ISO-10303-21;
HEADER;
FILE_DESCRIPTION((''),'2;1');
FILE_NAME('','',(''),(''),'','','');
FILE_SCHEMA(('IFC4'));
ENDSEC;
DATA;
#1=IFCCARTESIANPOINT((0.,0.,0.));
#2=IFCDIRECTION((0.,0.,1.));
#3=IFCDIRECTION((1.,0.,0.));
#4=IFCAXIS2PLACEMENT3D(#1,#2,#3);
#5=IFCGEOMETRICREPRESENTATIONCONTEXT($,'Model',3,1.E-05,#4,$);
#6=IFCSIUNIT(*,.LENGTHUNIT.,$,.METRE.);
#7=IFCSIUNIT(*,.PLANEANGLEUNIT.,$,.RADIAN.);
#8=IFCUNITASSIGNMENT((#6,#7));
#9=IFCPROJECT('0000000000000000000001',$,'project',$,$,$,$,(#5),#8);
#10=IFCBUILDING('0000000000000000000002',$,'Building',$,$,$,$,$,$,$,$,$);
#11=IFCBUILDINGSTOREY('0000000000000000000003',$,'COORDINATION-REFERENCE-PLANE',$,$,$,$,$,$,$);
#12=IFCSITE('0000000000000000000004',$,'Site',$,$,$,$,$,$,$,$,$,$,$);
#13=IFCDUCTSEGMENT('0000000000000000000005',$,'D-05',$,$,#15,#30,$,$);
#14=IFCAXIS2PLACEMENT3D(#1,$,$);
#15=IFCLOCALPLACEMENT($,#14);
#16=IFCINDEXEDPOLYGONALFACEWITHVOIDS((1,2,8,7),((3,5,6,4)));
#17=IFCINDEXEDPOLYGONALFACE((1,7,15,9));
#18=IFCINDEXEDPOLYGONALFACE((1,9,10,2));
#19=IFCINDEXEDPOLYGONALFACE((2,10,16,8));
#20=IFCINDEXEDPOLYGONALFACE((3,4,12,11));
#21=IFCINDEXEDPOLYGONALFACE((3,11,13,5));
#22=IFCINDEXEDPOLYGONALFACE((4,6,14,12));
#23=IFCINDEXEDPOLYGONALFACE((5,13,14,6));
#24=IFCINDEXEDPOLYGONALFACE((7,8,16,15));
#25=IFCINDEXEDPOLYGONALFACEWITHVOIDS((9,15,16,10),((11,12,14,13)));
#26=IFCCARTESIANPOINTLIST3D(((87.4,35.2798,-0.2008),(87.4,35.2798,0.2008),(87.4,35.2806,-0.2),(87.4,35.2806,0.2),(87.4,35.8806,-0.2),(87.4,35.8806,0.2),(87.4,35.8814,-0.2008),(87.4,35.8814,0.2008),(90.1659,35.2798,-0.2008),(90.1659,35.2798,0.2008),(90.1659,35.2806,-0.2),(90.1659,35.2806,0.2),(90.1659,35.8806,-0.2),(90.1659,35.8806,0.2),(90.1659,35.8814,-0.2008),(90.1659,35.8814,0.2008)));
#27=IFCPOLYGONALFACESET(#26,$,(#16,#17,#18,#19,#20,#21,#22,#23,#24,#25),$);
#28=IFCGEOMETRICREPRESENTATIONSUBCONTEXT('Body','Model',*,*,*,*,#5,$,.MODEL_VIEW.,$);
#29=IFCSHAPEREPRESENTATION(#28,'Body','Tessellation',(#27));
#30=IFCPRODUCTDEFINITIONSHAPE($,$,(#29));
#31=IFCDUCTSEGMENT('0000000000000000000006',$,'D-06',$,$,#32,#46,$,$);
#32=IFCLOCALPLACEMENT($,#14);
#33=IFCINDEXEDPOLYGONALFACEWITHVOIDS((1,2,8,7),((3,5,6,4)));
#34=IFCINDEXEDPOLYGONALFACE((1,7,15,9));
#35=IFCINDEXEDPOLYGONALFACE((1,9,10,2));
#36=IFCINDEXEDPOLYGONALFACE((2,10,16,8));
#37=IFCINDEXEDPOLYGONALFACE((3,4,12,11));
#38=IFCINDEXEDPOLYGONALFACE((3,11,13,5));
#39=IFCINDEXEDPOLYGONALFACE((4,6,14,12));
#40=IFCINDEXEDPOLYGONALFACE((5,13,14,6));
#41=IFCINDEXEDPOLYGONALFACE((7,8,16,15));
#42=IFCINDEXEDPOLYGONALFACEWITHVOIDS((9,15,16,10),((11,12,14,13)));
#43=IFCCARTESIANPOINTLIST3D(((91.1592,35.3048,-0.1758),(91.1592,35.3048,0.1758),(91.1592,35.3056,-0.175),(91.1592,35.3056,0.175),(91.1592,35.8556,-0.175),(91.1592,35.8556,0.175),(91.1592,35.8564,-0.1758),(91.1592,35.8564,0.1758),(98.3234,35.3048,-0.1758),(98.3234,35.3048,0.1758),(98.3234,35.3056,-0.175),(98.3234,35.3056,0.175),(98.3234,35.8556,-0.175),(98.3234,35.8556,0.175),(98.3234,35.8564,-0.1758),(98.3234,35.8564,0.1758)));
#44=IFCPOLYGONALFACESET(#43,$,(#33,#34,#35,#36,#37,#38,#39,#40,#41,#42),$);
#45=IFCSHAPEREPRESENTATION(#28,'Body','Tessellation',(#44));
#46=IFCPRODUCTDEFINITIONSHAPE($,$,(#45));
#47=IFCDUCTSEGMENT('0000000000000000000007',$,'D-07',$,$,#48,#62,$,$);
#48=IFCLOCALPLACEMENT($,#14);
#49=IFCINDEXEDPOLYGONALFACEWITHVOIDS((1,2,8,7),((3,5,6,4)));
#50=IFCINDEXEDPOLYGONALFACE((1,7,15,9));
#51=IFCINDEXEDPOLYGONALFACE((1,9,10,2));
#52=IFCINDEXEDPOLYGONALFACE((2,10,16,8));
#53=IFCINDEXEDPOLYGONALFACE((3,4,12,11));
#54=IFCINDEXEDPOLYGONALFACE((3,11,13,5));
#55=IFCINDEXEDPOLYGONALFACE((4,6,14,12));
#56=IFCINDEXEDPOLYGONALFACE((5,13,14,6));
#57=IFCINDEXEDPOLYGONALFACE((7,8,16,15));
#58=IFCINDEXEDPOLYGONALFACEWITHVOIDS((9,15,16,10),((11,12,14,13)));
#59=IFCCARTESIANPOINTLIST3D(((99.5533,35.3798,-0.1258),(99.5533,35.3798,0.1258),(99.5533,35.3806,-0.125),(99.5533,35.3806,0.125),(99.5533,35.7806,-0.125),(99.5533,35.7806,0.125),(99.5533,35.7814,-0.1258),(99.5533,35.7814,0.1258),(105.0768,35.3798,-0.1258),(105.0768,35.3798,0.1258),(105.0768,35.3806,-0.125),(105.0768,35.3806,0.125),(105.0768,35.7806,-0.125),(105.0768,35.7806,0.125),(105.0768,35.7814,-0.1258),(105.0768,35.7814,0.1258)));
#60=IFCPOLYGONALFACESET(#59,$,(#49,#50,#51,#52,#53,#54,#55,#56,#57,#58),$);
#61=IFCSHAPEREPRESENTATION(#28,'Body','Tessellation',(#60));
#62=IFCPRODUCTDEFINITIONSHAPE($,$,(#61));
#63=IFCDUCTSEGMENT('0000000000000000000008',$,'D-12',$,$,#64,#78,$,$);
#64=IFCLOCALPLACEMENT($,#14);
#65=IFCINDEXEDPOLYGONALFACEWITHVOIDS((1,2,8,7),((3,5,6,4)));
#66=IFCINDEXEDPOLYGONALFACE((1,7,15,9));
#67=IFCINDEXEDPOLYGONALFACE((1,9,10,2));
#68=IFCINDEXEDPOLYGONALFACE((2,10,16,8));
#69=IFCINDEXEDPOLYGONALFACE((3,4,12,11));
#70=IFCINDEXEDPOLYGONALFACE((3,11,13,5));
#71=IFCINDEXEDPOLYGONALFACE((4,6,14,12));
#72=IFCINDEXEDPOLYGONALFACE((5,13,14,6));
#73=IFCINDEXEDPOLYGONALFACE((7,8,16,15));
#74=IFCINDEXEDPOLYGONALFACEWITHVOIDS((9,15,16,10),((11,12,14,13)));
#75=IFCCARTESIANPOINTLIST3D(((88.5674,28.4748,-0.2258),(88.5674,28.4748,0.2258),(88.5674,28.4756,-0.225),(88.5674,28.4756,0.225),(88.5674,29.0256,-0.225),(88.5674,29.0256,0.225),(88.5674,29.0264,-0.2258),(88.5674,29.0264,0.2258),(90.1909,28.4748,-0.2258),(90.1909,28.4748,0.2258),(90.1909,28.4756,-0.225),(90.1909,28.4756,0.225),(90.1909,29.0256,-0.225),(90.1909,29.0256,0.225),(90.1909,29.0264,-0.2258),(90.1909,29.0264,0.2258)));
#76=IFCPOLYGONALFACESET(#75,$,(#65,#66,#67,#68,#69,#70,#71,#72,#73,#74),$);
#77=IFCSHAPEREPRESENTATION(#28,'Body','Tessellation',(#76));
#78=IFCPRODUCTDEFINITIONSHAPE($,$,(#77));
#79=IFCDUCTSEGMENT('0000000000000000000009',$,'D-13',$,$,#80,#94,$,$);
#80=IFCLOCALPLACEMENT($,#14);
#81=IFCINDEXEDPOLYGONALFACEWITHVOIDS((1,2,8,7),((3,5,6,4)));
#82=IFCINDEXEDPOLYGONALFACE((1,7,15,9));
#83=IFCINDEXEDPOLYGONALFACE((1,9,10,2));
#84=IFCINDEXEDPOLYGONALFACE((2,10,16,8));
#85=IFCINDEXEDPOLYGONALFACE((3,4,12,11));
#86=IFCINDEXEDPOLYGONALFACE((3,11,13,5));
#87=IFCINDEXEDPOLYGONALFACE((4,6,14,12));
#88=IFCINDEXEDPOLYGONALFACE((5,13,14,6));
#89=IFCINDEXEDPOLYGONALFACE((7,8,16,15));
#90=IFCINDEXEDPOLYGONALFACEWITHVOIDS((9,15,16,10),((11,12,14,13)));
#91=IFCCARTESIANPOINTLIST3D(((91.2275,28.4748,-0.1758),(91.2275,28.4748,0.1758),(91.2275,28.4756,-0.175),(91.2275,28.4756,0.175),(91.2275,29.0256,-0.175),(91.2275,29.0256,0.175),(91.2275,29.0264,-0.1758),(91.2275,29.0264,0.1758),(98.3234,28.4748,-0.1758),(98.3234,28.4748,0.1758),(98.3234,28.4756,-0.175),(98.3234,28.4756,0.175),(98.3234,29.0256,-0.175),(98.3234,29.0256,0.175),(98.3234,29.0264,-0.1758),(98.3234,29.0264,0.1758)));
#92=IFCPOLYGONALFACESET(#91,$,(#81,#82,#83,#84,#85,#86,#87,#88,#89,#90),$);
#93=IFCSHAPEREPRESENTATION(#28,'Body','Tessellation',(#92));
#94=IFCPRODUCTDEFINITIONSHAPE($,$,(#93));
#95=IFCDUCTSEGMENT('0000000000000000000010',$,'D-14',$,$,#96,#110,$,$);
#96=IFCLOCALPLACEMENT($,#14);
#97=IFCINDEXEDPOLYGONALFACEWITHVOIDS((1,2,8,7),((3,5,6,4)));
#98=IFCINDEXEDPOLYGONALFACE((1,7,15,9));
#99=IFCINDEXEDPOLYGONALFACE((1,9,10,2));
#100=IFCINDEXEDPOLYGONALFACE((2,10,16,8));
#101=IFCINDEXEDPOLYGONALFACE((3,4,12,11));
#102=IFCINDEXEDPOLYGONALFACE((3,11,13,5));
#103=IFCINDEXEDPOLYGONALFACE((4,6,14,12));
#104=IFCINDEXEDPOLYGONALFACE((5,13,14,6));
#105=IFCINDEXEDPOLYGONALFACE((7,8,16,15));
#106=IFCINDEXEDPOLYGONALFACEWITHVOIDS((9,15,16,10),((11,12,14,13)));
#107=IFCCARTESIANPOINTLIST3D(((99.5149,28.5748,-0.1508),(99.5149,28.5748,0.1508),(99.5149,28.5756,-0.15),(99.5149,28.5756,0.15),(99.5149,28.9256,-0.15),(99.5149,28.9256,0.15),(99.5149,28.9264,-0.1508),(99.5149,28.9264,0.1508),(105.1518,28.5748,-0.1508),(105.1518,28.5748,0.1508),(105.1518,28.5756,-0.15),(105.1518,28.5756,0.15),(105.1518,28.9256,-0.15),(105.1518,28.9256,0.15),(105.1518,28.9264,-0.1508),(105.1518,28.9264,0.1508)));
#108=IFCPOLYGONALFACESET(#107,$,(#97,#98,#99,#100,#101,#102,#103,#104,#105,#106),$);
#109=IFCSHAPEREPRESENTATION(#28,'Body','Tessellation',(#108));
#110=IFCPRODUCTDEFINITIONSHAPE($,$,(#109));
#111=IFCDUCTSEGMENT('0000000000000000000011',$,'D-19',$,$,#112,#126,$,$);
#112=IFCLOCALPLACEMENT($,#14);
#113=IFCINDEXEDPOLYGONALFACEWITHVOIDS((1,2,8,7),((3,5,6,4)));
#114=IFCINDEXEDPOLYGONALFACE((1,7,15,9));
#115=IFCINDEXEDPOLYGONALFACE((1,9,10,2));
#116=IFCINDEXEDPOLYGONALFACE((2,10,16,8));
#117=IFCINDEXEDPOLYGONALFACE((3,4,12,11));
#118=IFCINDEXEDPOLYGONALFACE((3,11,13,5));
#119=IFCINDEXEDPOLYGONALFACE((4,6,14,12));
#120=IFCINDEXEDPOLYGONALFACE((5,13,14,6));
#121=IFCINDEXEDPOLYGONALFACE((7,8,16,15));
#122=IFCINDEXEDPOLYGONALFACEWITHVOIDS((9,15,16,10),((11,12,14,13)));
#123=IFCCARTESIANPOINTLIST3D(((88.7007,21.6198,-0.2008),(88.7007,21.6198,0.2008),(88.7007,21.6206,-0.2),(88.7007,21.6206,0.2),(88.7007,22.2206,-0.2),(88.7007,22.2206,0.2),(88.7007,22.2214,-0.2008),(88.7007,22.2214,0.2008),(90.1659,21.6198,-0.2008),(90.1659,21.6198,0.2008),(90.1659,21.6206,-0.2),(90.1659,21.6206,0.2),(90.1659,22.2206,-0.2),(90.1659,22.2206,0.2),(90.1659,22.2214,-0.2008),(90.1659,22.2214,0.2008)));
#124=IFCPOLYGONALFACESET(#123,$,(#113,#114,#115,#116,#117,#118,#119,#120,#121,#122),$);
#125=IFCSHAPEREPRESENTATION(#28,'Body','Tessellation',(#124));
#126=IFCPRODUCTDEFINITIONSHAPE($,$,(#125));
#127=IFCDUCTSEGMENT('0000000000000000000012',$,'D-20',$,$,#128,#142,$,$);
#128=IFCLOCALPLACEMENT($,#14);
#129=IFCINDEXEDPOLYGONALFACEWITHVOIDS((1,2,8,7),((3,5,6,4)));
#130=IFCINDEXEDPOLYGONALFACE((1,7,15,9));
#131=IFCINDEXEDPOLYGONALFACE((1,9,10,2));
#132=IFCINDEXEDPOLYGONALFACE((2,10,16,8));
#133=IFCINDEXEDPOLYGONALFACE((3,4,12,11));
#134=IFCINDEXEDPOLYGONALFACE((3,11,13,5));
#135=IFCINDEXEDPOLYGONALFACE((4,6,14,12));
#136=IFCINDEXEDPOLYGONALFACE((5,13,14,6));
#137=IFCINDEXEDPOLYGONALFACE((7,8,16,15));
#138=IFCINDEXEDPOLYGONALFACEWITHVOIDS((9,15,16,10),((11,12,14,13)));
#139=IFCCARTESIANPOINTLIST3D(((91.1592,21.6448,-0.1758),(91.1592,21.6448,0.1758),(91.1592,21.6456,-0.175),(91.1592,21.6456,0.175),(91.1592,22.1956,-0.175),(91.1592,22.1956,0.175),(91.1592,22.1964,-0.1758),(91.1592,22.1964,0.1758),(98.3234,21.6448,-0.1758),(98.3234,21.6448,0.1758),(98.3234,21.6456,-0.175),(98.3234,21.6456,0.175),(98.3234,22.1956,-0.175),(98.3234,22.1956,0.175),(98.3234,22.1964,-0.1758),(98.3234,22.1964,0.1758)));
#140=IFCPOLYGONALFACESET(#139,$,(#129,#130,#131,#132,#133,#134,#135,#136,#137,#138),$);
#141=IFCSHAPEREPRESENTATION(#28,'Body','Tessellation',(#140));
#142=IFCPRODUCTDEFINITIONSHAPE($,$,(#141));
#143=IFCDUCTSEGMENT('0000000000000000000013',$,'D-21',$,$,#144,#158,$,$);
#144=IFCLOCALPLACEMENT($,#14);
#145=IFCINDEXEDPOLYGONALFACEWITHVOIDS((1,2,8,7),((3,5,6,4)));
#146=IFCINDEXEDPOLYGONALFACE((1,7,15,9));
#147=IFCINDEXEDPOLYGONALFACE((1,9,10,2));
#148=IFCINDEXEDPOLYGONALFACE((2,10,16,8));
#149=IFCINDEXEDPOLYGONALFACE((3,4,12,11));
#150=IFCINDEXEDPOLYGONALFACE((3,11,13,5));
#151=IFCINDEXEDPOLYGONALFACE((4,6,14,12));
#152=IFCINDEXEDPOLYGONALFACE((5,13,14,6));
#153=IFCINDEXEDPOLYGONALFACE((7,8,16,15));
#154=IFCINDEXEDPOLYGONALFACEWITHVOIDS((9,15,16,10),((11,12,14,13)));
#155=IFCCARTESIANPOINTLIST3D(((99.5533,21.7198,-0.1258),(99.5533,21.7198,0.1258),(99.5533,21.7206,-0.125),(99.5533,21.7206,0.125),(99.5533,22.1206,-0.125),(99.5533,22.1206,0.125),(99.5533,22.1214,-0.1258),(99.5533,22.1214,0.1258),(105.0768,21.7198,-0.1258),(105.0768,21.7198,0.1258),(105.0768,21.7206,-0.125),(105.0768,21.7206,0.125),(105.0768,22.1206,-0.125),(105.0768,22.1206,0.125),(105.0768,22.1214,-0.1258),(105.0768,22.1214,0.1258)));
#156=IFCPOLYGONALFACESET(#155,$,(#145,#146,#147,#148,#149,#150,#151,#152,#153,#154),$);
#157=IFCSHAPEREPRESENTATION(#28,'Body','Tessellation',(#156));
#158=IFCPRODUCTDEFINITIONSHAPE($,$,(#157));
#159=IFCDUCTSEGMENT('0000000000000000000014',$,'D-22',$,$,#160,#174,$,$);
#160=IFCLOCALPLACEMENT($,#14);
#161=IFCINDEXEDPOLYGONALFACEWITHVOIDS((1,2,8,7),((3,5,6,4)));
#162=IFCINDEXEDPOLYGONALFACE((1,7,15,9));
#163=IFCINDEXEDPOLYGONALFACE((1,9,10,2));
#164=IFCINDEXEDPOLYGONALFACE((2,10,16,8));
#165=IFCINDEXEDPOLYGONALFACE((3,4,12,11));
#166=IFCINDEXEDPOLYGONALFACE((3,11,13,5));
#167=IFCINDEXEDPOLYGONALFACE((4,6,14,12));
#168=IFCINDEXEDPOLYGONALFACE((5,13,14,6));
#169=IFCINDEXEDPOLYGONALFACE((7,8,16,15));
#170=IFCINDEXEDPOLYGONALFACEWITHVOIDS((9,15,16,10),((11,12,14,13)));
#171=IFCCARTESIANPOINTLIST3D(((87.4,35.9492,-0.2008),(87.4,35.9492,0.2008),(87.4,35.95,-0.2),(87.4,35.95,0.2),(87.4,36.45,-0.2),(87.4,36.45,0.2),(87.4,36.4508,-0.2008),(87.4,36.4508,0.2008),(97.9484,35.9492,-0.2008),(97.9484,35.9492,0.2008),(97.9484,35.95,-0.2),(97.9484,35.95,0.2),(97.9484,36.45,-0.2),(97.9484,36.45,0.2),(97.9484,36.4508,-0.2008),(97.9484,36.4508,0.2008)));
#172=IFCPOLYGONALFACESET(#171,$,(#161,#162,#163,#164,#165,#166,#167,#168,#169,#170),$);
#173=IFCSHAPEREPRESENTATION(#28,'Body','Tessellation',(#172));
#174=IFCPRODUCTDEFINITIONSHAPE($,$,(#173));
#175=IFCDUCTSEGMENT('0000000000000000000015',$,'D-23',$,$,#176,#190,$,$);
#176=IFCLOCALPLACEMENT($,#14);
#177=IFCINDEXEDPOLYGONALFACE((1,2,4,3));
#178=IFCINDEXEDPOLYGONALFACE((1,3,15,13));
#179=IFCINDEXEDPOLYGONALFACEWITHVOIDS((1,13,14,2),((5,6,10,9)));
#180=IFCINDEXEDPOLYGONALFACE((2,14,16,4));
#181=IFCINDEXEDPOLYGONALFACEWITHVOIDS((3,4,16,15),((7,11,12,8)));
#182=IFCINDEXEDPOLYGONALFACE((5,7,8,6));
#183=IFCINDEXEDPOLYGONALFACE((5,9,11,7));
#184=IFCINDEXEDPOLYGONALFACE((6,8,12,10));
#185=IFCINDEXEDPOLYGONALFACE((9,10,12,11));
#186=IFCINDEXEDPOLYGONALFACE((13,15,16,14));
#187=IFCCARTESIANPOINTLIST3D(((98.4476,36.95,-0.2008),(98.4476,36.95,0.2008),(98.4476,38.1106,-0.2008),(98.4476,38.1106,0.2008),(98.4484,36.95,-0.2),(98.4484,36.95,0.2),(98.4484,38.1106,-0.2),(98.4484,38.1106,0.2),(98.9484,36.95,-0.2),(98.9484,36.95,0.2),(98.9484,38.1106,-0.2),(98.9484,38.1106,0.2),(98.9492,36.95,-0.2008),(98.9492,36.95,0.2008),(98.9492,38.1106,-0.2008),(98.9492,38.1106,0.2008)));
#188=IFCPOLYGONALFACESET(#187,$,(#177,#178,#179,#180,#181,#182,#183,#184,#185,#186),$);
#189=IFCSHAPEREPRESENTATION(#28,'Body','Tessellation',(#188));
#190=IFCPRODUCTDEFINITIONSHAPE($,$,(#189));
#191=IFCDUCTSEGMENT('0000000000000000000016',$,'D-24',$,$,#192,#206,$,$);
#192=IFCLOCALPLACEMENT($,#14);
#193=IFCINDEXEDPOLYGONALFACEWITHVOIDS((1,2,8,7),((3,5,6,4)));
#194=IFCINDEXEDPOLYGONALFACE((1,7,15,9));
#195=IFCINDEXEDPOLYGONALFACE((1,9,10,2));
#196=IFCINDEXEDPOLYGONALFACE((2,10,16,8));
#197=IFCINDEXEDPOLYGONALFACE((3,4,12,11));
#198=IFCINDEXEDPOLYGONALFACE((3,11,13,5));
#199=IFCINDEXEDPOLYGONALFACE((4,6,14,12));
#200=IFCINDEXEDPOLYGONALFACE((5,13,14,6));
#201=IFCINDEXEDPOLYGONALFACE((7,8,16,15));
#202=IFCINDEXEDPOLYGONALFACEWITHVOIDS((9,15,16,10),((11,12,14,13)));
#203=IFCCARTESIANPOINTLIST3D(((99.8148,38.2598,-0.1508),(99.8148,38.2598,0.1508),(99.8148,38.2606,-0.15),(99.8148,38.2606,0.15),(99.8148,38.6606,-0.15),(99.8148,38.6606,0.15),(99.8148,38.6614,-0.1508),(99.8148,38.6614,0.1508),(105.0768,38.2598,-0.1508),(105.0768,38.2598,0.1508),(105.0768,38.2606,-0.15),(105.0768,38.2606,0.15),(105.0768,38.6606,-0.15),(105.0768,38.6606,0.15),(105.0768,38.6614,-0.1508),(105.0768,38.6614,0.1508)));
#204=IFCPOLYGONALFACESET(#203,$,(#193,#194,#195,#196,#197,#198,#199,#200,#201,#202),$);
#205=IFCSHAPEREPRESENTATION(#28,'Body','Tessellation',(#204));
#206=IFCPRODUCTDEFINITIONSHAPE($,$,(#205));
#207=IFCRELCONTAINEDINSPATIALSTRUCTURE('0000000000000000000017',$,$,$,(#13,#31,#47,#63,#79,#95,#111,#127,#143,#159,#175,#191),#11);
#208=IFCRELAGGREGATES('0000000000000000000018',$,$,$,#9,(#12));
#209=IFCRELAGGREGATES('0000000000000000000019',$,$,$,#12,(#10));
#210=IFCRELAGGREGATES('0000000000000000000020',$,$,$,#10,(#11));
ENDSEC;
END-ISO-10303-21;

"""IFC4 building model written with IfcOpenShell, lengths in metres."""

from ifc_helpers import new_model, si_unit, frame, origin, origin_with_axes, place, context, subcontext, project, spatial, hollow_rectangle, extrude, element, save


model = new_model("IFC4")

# Units and contexts
model_context = context("Model", 3, precision=1e-05, world=origin_with_axes())
body_context = subcontext(model_context, "Body", "Model", "MODEL_VIEW")
ifc_project = project(units=[si_unit("LENGTHUNIT", "METRE"), si_unit("PLANEANGLEUNIT", "RADIAN")], contexts=[model_context])

# Site, building, storey
site = spatial("IfcSite", under=ifc_project, Name="Site")
building = spatial("IfcBuilding", under=site, Name="Building")
storey = spatial("IfcBuildingStorey", under=building, Name="COORDINATION-REFERENCE-PLANE")

# Duct segments
duct_segment_1_placement = place(None, frame((87.4, 35.5806, 0.0), z_axis=(1.0, 0.0, 0.0), x_axis=(0.0, 1.0, 0.0)))
element("IfcDuctSegment", 1, at=duct_segment_1_placement, inside=storey, Name="D-05", context=body_context, shape_type="SweptSolid", body=[
    extrude(hollow_rectangle(XDim=0.6016, YDim=0.4016, WallThickness=0.0008), origin(), (0.0, 0.0, 1.0), 2.7659),
])
duct_segment_2_placement = place(None, frame((91.1592, 35.5806, 0.0), z_axis=(1.0, 0.0, 0.0), x_axis=(0.0, 1.0, 0.0)))
element("IfcDuctSegment", 2, at=duct_segment_2_placement, inside=storey, Name="D-06", context=body_context, shape_type="SweptSolid", body=[
    extrude(hollow_rectangle(XDim=0.5516, YDim=0.3516, WallThickness=0.0008), origin(), (0.0, 0.0, 1.0), 7.1642),
])
duct_segment_3_placement = place(None, frame((99.5533, 35.5806, 0.0), z_axis=(1.0, 0.0, 0.0), x_axis=(0.0, 1.0, 0.0)))
element("IfcDuctSegment", 3, at=duct_segment_3_placement, inside=storey, Name="D-07", context=body_context, shape_type="SweptSolid", body=[
    extrude(hollow_rectangle(XDim=0.4016, YDim=0.2516, WallThickness=0.0008), origin(), (0.0, 0.0, 1.0), 5.5234),
])
duct_segment_4_placement = place(None, frame((88.5674, 28.7506, 0.0), z_axis=(1.0, 0.0, 0.0), x_axis=(0.0, 1.0, 0.0)))
element("IfcDuctSegment", 4, at=duct_segment_4_placement, inside=storey, Name="D-12", context=body_context, shape_type="SweptSolid", body=[
    extrude(hollow_rectangle(XDim=0.5516, YDim=0.4516, WallThickness=0.0008), origin(), (0.0, 0.0, 1.0), 1.6235),
])
duct_segment_5_placement = place(None, frame((91.2275, 28.7506, 0.0), z_axis=(1.0, 0.0, 0.0), x_axis=(0.0, 1.0, 0.0)))
element("IfcDuctSegment", 5, at=duct_segment_5_placement, inside=storey, Name="D-13", context=body_context, shape_type="SweptSolid", body=[
    extrude(hollow_rectangle(XDim=0.5516, YDim=0.3516, WallThickness=0.0008), origin(), (0.0, 0.0, 1.0), 7.0959),
])
duct_segment_6_placement = place(None, frame((99.5149, 28.7506, 0.0), z_axis=(1.0, 0.0, 0.0), x_axis=(0.0, 1.0, 0.0)))
element("IfcDuctSegment", 6, at=duct_segment_6_placement, inside=storey, Name="D-14", context=body_context, shape_type="SweptSolid", body=[
    extrude(hollow_rectangle(XDim=0.3516, YDim=0.3016, WallThickness=0.0008), origin(), (0.0, 0.0, 1.0), 5.6369),
])
duct_segment_7_placement = place(None, frame((88.7007, 21.9206, 0.0), z_axis=(1.0, 0.0, 0.0), x_axis=(0.0, 1.0, 0.0)))
element("IfcDuctSegment", 7, at=duct_segment_7_placement, inside=storey, Name="D-19", context=body_context, shape_type="SweptSolid", body=[
    extrude(hollow_rectangle(XDim=0.6016, YDim=0.4016, WallThickness=0.0008), origin(), (0.0, 0.0, 1.0), 1.4652),
])
duct_segment_8_placement = place(None, frame((91.1592, 21.9206, 0.0), z_axis=(1.0, 0.0, 0.0), x_axis=(0.0, 1.0, 0.0)))
element("IfcDuctSegment", 8, at=duct_segment_8_placement, inside=storey, Name="D-20", context=body_context, shape_type="SweptSolid", body=[
    extrude(hollow_rectangle(XDim=0.5516, YDim=0.3516, WallThickness=0.0008), origin(), (0.0, 0.0, 1.0), 7.1642),
])
duct_segment_9_placement = place(None, frame((99.5533, 21.9206, 0.0), z_axis=(1.0, 0.0, 0.0), x_axis=(0.0, 1.0, 0.0)))
element("IfcDuctSegment", 9, at=duct_segment_9_placement, inside=storey, Name="D-21", context=body_context, shape_type="SweptSolid", body=[
    extrude(hollow_rectangle(XDim=0.4016, YDim=0.2516, WallThickness=0.0008), origin(), (0.0, 0.0, 1.0), 5.5234),
])
duct_segment_10_placement = place(None, frame((87.4, 36.2, 0.0), z_axis=(1.0, 0.0, 0.0), x_axis=(0.0, 1.0, 0.0)))
element("IfcDuctSegment", 10, at=duct_segment_10_placement, inside=storey, Name="D-22", context=body_context, shape_type="SweptSolid", body=[
    extrude(hollow_rectangle(XDim=0.5016, YDim=0.4016, WallThickness=0.0008), origin(), (0.0, 0.0, 1.0), 10.5484),
])
duct_segment_11_placement = place(None, frame((98.6984, 36.95, 0.0), z_axis=(0.0, 1.0, 0.0), x_axis=(1.0, 0.0, 0.0)))
element("IfcDuctSegment", 11, at=duct_segment_11_placement, inside=storey, Name="D-23", context=body_context, shape_type="SweptSolid", body=[
    extrude(hollow_rectangle(XDim=0.5016, YDim=0.4016, WallThickness=0.0008), origin(), (0.0, 0.0, 1.0), 1.1606),
])
duct_segment_12_placement = place(None, frame((99.8148, 38.4606, 0.0), z_axis=(1.0, 0.0, 0.0), x_axis=(0.0, 1.0, 0.0)))
element("IfcDuctSegment", 12, at=duct_segment_12_placement, inside=storey, Name="D-24", context=body_context, shape_type="SweptSolid", body=[
    extrude(hollow_rectangle(XDim=0.4016, YDim=0.3016, WallThickness=0.0008), origin(), (0.0, 0.0, 1.0), 5.2619),
])

save(model, "model.ifc")
